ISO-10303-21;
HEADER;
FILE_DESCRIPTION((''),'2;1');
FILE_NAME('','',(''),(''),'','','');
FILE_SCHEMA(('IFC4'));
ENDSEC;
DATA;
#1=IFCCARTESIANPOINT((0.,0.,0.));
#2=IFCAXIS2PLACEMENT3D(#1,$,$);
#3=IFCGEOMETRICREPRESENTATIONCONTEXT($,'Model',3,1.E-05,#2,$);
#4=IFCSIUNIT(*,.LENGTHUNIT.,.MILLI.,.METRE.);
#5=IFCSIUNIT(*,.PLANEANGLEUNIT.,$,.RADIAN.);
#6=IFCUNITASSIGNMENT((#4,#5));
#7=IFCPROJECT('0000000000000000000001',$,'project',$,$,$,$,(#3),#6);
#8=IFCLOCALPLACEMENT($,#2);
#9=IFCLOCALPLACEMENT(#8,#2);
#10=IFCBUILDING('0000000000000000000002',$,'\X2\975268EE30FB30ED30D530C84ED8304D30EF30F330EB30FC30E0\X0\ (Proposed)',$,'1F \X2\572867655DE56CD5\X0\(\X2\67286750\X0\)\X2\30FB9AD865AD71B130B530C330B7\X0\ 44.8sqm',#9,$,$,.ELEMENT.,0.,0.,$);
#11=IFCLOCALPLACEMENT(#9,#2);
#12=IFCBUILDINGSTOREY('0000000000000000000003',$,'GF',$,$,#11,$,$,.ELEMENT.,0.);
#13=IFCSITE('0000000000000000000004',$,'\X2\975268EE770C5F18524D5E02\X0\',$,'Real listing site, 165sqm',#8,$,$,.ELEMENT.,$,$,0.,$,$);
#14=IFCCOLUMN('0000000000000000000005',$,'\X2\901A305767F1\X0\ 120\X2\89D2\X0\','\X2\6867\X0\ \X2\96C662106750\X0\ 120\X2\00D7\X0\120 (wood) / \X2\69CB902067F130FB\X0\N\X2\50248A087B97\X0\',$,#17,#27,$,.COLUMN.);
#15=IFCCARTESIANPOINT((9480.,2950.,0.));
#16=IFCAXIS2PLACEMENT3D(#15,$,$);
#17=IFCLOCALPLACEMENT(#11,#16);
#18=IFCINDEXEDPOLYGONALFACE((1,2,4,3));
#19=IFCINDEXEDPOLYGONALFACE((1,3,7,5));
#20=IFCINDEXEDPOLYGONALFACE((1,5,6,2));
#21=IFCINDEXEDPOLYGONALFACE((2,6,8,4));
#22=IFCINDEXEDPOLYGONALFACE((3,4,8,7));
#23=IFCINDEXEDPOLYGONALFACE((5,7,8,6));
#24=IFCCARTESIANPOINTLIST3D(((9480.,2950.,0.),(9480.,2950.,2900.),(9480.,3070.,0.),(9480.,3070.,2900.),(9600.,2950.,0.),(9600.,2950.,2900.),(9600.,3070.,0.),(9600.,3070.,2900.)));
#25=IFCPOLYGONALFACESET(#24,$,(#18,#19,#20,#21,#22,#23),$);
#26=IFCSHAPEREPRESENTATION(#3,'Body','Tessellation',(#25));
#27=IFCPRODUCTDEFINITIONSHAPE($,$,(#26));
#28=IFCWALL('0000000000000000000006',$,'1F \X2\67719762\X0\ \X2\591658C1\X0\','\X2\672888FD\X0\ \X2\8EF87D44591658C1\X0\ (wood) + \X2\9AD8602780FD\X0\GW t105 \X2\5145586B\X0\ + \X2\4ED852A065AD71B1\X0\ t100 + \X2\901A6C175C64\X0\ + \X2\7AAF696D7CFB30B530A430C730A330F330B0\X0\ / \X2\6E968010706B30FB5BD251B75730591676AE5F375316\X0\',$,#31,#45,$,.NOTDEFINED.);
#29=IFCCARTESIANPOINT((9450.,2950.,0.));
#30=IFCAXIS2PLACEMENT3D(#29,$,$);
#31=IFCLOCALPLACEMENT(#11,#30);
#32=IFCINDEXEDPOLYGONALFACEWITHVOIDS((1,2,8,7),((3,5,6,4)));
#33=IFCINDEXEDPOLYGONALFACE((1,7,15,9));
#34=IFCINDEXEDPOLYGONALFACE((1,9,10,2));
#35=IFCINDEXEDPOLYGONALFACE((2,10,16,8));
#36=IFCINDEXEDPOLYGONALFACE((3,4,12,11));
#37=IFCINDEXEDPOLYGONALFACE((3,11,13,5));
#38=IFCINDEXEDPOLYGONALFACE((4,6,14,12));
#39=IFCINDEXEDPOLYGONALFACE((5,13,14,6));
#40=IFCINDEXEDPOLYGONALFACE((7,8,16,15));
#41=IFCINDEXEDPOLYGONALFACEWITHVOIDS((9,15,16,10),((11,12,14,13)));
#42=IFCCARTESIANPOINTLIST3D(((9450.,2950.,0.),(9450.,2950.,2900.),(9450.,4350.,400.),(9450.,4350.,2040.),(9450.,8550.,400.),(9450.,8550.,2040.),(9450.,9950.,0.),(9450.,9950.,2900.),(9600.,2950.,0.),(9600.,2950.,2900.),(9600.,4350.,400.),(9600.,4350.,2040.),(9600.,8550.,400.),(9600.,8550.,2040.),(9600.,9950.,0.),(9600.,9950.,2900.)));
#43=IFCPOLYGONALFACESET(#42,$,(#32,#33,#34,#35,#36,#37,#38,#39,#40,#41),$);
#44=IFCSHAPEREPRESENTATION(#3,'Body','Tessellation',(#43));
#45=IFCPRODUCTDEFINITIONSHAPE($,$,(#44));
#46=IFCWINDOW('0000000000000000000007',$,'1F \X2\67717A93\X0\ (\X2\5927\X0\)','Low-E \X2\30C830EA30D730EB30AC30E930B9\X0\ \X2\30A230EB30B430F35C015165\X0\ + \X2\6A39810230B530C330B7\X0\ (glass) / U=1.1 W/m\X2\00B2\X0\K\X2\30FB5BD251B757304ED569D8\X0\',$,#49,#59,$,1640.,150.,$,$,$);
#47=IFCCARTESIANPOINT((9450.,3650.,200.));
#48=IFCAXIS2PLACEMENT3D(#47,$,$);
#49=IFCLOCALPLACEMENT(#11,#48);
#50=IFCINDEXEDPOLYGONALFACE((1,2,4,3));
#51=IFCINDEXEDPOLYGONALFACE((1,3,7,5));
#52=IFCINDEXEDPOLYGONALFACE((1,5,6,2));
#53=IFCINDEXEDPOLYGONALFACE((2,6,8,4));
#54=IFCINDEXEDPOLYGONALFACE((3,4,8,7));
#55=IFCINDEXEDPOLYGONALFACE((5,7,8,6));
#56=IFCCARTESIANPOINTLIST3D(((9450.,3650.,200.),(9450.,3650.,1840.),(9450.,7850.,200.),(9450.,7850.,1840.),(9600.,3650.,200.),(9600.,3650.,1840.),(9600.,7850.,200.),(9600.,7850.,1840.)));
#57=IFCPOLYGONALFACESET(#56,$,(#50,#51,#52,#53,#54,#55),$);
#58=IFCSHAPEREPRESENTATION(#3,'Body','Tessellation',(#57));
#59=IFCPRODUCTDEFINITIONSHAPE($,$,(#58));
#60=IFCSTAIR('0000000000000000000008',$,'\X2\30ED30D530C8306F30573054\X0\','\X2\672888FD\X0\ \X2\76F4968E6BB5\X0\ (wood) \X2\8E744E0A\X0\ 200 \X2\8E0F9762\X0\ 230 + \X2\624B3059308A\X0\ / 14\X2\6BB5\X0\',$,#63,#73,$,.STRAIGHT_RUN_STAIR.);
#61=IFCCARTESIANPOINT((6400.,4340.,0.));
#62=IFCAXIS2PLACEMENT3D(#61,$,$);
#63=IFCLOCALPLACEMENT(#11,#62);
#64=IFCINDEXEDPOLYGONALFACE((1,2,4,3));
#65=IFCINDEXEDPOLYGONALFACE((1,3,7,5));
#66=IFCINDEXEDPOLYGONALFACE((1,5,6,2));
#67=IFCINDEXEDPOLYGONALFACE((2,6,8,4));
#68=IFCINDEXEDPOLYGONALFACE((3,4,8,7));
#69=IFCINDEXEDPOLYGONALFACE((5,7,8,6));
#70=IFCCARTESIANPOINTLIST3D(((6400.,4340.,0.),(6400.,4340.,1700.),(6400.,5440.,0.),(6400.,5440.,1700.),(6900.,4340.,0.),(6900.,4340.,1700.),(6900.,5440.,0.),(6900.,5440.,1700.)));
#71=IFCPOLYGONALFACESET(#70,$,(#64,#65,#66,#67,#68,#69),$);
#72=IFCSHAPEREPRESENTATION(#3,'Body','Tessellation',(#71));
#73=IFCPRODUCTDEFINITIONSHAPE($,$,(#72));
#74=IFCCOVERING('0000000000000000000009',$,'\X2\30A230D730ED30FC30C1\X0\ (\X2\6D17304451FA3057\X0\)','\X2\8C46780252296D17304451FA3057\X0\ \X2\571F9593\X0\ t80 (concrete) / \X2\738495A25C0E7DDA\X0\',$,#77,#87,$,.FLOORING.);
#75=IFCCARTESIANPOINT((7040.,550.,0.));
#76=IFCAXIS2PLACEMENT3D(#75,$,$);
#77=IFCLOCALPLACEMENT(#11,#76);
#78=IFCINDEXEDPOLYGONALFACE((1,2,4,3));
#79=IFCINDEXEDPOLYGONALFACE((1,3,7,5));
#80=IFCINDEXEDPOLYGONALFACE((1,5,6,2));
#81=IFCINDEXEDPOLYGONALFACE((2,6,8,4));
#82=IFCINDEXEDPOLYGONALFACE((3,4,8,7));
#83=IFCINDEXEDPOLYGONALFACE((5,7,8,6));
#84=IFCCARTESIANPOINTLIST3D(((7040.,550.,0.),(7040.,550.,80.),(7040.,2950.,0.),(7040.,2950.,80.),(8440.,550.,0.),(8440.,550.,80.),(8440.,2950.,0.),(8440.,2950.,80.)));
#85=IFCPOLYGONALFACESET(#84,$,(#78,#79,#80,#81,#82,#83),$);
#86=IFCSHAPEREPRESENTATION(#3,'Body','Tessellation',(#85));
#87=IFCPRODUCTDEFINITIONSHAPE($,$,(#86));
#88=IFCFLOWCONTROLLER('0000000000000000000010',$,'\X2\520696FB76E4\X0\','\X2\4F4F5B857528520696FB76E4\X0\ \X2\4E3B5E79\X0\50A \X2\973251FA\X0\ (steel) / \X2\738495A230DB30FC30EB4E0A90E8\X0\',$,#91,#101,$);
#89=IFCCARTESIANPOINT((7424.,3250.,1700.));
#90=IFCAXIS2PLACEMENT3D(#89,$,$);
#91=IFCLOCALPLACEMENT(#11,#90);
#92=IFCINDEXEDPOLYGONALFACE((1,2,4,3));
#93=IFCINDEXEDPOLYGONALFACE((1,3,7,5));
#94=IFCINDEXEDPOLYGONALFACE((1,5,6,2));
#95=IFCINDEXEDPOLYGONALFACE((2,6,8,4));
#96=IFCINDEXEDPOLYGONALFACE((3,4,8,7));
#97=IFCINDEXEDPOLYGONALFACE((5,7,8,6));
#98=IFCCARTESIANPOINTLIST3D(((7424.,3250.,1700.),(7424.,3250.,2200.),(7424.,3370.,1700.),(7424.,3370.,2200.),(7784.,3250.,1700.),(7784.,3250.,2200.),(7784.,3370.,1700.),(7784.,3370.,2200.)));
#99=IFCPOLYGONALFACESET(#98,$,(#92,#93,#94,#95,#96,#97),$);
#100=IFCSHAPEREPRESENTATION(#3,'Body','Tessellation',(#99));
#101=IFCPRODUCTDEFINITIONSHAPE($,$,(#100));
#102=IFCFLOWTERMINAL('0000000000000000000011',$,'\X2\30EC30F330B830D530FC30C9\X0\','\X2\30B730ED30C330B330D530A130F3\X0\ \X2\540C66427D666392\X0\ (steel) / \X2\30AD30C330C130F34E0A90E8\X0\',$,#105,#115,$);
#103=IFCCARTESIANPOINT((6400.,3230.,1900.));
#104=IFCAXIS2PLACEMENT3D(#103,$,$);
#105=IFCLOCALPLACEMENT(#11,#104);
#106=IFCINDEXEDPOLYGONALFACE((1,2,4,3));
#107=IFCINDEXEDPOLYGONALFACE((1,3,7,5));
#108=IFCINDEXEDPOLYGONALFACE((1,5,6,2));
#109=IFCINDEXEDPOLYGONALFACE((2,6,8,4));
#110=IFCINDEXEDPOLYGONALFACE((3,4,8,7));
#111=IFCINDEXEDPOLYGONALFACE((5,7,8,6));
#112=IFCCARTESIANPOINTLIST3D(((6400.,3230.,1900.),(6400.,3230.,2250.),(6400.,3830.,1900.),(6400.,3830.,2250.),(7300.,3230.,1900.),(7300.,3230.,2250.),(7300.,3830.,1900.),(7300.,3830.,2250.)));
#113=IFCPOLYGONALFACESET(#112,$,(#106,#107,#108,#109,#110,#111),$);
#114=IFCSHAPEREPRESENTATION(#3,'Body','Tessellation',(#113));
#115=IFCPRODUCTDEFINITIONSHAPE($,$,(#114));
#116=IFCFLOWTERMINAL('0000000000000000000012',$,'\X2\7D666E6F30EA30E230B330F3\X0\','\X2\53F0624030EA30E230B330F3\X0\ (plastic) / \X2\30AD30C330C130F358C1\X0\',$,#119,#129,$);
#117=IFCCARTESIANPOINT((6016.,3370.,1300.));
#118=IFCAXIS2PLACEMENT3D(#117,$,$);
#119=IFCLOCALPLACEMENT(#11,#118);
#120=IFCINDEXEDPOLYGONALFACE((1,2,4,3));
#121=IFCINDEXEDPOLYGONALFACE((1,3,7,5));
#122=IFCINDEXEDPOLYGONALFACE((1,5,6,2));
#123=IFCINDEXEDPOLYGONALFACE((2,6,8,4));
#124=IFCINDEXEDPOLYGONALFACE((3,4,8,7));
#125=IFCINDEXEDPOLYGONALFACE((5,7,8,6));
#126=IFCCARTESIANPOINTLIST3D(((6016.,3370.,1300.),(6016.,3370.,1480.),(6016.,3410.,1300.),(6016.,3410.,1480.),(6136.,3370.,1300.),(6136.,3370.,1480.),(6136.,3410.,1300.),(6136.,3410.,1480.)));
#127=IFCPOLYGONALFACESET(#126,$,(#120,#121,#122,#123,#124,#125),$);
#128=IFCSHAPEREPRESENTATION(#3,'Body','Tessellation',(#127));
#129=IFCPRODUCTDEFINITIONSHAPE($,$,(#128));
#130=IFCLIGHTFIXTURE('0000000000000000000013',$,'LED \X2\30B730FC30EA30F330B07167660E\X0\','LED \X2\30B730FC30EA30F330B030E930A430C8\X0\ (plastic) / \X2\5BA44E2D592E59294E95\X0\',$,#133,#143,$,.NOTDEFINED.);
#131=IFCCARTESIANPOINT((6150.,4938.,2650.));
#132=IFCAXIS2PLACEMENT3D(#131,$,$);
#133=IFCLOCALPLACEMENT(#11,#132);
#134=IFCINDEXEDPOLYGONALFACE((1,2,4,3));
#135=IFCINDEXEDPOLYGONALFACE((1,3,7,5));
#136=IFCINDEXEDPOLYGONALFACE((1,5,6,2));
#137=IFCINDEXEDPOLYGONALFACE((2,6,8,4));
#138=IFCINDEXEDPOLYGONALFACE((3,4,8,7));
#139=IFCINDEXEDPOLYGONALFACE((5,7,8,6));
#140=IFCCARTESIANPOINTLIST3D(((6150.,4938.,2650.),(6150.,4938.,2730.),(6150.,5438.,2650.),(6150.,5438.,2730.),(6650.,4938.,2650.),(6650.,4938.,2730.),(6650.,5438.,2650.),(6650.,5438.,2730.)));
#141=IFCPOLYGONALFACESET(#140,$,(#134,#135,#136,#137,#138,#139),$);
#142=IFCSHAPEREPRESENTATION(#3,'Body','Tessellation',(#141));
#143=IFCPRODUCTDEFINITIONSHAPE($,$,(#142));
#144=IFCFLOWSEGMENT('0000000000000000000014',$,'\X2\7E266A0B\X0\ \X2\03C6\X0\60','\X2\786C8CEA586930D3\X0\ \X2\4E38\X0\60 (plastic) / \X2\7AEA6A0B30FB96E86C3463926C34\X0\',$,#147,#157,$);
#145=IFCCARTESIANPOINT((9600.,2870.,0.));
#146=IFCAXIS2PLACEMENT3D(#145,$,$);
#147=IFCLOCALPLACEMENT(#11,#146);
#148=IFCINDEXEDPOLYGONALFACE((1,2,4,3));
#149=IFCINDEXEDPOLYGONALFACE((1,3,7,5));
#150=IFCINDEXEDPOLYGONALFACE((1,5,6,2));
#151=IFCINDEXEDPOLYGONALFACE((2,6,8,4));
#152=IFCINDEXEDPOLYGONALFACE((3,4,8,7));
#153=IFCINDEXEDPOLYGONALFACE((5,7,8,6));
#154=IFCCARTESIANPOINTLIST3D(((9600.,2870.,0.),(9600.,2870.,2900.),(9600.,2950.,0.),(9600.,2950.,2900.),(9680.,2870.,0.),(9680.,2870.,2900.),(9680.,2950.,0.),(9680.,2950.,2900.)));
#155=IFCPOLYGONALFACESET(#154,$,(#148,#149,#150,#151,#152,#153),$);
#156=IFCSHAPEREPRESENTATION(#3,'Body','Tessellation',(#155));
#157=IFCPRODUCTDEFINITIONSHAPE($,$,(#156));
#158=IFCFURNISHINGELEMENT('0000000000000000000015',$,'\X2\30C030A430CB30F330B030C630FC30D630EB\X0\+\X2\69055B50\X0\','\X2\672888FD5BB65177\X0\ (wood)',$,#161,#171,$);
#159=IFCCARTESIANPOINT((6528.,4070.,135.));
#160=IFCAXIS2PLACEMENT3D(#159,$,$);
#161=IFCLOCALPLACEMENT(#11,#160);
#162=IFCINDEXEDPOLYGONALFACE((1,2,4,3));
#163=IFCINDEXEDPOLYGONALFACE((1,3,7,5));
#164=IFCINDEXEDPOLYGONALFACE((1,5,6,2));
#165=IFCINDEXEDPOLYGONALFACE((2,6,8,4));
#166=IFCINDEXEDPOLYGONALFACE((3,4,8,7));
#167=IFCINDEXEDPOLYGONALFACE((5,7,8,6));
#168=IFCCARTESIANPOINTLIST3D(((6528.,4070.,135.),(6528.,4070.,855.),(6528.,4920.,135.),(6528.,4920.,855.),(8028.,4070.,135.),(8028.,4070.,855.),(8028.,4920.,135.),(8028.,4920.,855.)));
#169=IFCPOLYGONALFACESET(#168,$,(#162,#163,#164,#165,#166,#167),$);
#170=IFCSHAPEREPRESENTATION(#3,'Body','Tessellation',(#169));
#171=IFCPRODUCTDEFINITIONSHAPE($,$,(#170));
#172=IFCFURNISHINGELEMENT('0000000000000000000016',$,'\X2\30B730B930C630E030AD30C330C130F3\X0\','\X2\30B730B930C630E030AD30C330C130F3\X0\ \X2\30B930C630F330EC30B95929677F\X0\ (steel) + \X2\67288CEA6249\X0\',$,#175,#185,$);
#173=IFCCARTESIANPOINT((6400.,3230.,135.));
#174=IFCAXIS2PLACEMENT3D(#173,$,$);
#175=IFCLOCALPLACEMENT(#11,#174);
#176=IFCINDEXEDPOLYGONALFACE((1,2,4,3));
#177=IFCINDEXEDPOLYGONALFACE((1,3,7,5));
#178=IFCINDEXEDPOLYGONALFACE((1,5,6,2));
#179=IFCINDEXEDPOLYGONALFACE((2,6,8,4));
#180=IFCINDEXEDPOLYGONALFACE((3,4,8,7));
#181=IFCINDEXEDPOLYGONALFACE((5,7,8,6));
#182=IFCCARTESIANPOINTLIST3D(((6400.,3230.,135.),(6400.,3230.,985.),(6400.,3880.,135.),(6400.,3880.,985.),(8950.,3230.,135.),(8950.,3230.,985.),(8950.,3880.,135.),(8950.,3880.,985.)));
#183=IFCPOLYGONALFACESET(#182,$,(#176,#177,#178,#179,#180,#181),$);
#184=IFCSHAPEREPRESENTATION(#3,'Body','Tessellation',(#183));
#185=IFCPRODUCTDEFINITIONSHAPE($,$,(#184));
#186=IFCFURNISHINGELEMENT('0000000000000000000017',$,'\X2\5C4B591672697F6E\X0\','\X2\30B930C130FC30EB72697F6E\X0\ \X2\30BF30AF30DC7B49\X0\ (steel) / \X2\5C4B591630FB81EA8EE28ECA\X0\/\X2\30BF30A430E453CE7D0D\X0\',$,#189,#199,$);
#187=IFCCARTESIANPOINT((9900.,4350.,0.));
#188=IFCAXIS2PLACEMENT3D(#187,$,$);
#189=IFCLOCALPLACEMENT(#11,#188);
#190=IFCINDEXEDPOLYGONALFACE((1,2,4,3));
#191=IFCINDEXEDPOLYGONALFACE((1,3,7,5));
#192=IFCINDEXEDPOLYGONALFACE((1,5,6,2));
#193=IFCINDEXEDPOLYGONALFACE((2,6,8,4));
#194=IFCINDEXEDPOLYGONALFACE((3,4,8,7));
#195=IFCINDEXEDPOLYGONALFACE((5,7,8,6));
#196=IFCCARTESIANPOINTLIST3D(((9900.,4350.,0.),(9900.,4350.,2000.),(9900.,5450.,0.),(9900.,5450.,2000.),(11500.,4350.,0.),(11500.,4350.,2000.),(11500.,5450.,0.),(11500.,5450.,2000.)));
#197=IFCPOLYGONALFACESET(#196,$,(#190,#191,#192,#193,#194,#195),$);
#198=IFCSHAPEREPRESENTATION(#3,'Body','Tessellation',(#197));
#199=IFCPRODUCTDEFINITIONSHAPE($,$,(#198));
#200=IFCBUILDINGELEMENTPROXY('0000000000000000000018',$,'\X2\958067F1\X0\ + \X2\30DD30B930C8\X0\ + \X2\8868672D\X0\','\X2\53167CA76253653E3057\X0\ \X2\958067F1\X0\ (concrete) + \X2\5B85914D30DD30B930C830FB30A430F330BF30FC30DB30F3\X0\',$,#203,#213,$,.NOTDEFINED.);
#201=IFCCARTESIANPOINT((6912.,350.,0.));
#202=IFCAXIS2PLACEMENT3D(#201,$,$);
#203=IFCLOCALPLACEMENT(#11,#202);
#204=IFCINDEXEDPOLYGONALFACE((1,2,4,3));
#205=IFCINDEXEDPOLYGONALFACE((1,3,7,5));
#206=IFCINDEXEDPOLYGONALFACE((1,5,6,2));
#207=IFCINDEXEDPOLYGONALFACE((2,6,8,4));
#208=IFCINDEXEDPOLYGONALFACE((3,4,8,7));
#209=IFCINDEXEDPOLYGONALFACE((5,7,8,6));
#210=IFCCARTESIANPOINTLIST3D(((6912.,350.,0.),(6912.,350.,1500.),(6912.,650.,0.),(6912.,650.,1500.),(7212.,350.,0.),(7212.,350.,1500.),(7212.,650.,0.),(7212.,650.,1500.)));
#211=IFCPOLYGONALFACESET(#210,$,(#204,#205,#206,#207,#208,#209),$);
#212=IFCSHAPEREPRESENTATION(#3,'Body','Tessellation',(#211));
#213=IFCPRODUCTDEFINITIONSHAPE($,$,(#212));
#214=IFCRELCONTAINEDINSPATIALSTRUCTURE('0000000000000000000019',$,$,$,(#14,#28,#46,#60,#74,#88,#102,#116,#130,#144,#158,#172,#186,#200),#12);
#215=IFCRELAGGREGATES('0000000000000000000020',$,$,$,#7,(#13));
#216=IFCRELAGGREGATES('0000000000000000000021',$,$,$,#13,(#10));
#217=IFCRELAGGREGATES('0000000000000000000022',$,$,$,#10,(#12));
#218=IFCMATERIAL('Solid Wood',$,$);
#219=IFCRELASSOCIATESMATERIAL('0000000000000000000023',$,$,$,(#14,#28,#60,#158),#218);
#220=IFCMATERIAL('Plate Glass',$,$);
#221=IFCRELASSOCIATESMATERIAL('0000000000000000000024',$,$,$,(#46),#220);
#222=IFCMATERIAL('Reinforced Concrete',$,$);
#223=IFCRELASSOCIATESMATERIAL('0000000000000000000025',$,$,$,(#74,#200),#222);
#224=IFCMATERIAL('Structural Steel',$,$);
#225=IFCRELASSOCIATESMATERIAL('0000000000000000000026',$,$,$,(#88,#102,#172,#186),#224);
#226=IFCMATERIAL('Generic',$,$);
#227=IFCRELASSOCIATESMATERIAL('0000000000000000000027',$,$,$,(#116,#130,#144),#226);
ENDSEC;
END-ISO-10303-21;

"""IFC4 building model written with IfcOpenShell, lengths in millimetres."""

from ifc_helpers import new_model, si_unit, frame, frame_2d, origin, place, context, project, spatial, rectangle, extrude, material, element, fill, save


model = new_model("IFC4")

# Units and contexts
model_context = context("Model", 3, precision=1e-05, world=origin())
ifc_project = project(units=[si_unit("LENGTHUNIT", "METRE", prefix="MILLI"), si_unit("PLANEANGLEUNIT", "RADIAN")], contexts=[model_context])

# Site, building, storey
site_placement = place(None, origin())
site = spatial("IfcSite", under=ifc_project, at=site_placement, Name="青森県弘前市", ObjectType="Real listing site, 165sqm", CompositionType="ELEMENT", RefElevation=0.0)
building_placement = place(site_placement, origin())
building = spatial("IfcBuilding", under=site, at=building_placement, Name="青森・ロフト付きワンルーム (Proposed)", ObjectType="1F 在来工法(木材)・高断熱サッシ 44.8sqm", CompositionType="ELEMENT", ElevationOfRefHeight=0.0, ElevationOfTerrain=0.0)
storey_placement = place(building_placement, origin())
storey = spatial("IfcBuildingStorey", under=building, at=storey_placement, Name="GF", CompositionType="ELEMENT", Elevation=0.0)

# Column
ifc_material_1 = material(Name="Solid Wood")
column_1_placement = place(storey_placement, frame((9480.0, 2950.0, 0.0)))
element("IfcColumn", 1, at=column_1_placement, inside=storey, material=ifc_material_1, Name="通し柱 120角", Description="桧 集成材 120×120 (wood) / 構造柱・N値計算", PredefinedType="COLUMN", context=model_context, shape_type="SweptSolid", body=[
    extrude(rectangle(XDim=120.0, YDim=120.0, at=frame_2d((60.0, 60.0))), frame((9480.0, 2950.0, 0.0)), (0.0, 0.0, 1.0), 2900.0),
])

# Wall, opening, window
wall_1_placement = place(storey_placement, frame((9450.0, 2950.0, 0.0)))
wall_1 = element("IfcWall", 2, at=wall_1_placement, inside=storey, material=ifc_material_1, Name="1F 東面 外壁", Description="木製 軸組外壁 (wood) + 高性能GW t105 充填 + 付加断熱 t100 + 通気層 + 窯業系サイディング / 準耐火・寒冷地外皮強化", PredefinedType="NOTDEFINED", context=model_context, shape_type="SweptSolid", body=[
    extrude(rectangle(XDim=150.0, YDim=7000.0, at=frame_2d((75.0, 3500.0))), frame((9450.0, 2950.0, 0.0)), (0.0, 0.0, 1.0), 2900.0),
])
opening_placement = place(storey_placement, frame((9450.0, 3650.0, 200.0)))
opening = element("IfcOpeningElement", 3, at=opening_placement, cuts=wall_1, PredefinedType="NOTDEFINED", context=model_context, shape_type="SweptSolid", body=[
    extrude(rectangle(XDim=150.0, YDim=4200.0, at=frame_2d((75.0, 2100.0))), frame((9450.0, 3650.0, 200.0)), (0.0, 0.0, 1.0), 1640.0),
])
ifc_material_2 = material(Name="Plate Glass")
window_placement = place(storey_placement, frame((9450.0, 3650.0, 200.0)))
window = element("IfcWindow", 4, at=window_placement, inside=storey, material=ifc_material_2, Name="1F 東窓 (大)", Description="Low-E トリプルガラス アルゴン封入 + 樹脂サッシ (glass) / U=1.1 W/m²K・寒冷地仕様", OverallHeight=1640.0, OverallWidth=150.0, context=model_context, shape_type="SweptSolid", body=[
    extrude(rectangle(XDim=150.0, YDim=4200.0, at=frame_2d((75.0, 2100.0))), frame((9450.0, 3650.0, 200.0)), (0.0, 0.0, 1.0), 1640.0),
])
fill(opening, window)

# Stair
stair_placement = place(storey_placement, frame((6400.0, 4340.0, 0.0)))
element("IfcStair", 5, at=stair_placement, inside=storey, material=ifc_material_1, Name="ロフトはしご", Description="木製 直階段 (wood) 蹴上 200 踏面 230 + 手すり / 14段", PredefinedType="STRAIGHT_RUN_STAIR", context=model_context, shape_type="SweptSolid", body=[
    extrude(rectangle(XDim=500.0, YDim=1100.0, at=frame_2d((250.0, 550.0))), frame((6400.0, 4340.0, 0.0)), (0.0, 0.0, 1.0), 1700.0),
])

# Covering
ifc_material_3 = material(Name="Reinforced Concrete")
covering_placement = place(storey_placement, frame((7040.0, 550.0, 0.0)))
element("IfcCovering", 6, at=covering_placement, inside=storey, material=ifc_material_3, Name="アプローチ (洗い出し)", Description="豆砂利洗い出し 土間 t80 (concrete) / 玄関導線", PredefinedType="FLOORING", context=model_context, shape_type="SweptSolid", body=[
    extrude(rectangle(XDim=1400.0, YDim=2400.0, at=frame_2d((700.0, 1200.0))), frame((7040.0, 550.0, 0.0)), (0.0, 0.0, 1.0), 80.0),
])

# Flow controller
ifc_material_4 = material(Name="Structural Steel")
flow_controller_placement = place(storey_placement, frame((7424.0, 3250.0, 1700.0)))
element("IfcFlowController", 7, at=flow_controller_placement, inside=storey, material=ifc_material_4, Name="分電盤", Description="住宅用分電盤 主幹50A 露出 (steel) / 玄関ホール上部", context=model_context, shape_type="SweptSolid", body=[
    extrude(rectangle(XDim=360.0, YDim=120.0, at=frame_2d((180.0, 60.0))), frame((7424.0, 3250.0, 1700.0)), (0.0, 0.0, 1.0), 500.0),
])

# Flow terminals
flow_terminal_1_placement = place(storey_placement, frame((6400.0, 3230.0, 1900.0)))
element("IfcFlowTerminal", 8, at=flow_terminal_1_placement, inside=storey, material=ifc_material_4, Name="レンジフード", Description="シロッコファン 同時給排 (steel) / キッチン上部", context=model_context, shape_type="SweptSolid", body=[
    extrude(rectangle(XDim=900.0, YDim=600.0, at=frame_2d((450.0, 300.0))), frame((6400.0, 3230.0, 1900.0)), (0.0, 0.0, 1.0), 350.0),
])
ifc_material_5 = material(Name="Generic")
flow_terminal_2_placement = place(storey_placement, frame((6016.0, 3370.0, 1300.0)))
element("IfcFlowTerminal", 9, at=flow_terminal_2_placement, inside=storey, material=ifc_material_5, Name="給湯リモコン", Description="台所リモコン (plastic) / キッチン壁", context=model_context, shape_type="SweptSolid", body=[
    extrude(rectangle(XDim=120.0, YDim=40.0, at=frame_2d((60.0, 20.0))), frame((6016.0, 3370.0, 1300.0)), (0.0, 0.0, 1.0), 180.0),
])

# Light fixture
light_fixture_placement = place(storey_placement, frame((6150.0, 4938.0, 2650.0)))
element("IfcLightFixture", 10, at=light_fixture_placement, inside=storey, material=ifc_material_5, Name="LED シーリング照明", Description="LED シーリングライト (plastic) / 室中央天井", PredefinedType="NOTDEFINED", context=model_context, shape_type="SweptSolid", body=[
    extrude(rectangle(XDim=500.0, YDim=500.0, at=frame_2d((250.0, 250.0))), frame((6150.0, 4938.0, 2650.0)), (0.0, 0.0, 1.0), 80.0),
])

# Flow segment
flow_segment_placement = place(storey_placement, frame((9600.0, 2870.0, 0.0)))
element("IfcFlowSegment", 11, at=flow_segment_placement, inside=storey, material=ifc_material_5, Name="縦樋 φ60", Description="硬質塩ビ 丸60 (plastic) / 竪樋・雨水排水", context=model_context, shape_type="SweptSolid", body=[
    extrude(rectangle(XDim=80.0, YDim=80.0, at=frame_2d((40.0, 40.0))), frame((9600.0, 2870.0, 0.0)), (0.0, 0.0, 1.0), 2900.0),
])

# Furnishing elements
furnishing_1_placement = place(storey_placement, frame((6528.0, 4070.0, 135.0)))
element("IfcFurnishingElement", 12, at=furnishing_1_placement, inside=storey, material=ifc_material_1, Name="ダイニングテーブル+椅子", Description="木製家具 (wood)", context=model_context, shape_type="SweptSolid", body=[
    extrude(rectangle(XDim=1500.0, YDim=850.0, at=frame_2d((750.0, 425.0))), frame((6528.0, 4070.0, 135.0)), (0.0, 0.0, 1.0), 720.0),
])
furnishing_2_placement = place(storey_placement, frame((6400.0, 3230.0, 135.0)))
element("IfcFurnishingElement", 13, at=furnishing_2_placement, inside=storey, material=ifc_material_4, Name="システムキッチン", Description="システムキッチン ステンレス天板 (steel) + 木質扉", context=model_context, shape_type="SweptSolid", body=[
    extrude(rectangle(XDim=2550.0, YDim=650.0, at=frame_2d((1275.0, 325.0))), frame((6400.0, 3230.0, 135.0)), (0.0, 0.0, 1.0), 850.0),
])
furnishing_3_placement = place(storey_placement, frame((9900.0, 4350.0, 0.0)))
element("IfcFurnishingElement", 14, at=furnishing_3_placement, inside=storey, material=ifc_material_4, Name="屋外物置", Description="スチール物置 タクボ等 (steel) / 屋外・自転車/タイヤ収納", context=model_context, shape_type="SweptSolid", body=[
    extrude(rectangle(XDim=1600.0, YDim=1100.0, at=frame_2d((800.0, 550.0))), frame((9900.0, 4350.0, 0.0)), (0.0, 0.0, 1.0), 2000.0),
])

# Building element proxy
proxy_placement = place(storey_placement, frame((6912.0, 350.0, 0.0)))
element("IfcBuildingElementProxy", 15, at=proxy_placement, inside=storey, material=ifc_material_3, Name="門柱 + ポスト + 表札", Description="化粧打放し 門柱 (concrete) + 宅配ポスト・インターホン", PredefinedType="NOTDEFINED", context=model_context, shape_type="SweptSolid", body=[
    extrude(rectangle(XDim=300.0, YDim=300.0, at=frame_2d((150.0, 150.0))), frame((6912.0, 350.0, 0.0)), (0.0, 0.0, 1.0), 1500.0),
])

save(model, "model.ifc")
